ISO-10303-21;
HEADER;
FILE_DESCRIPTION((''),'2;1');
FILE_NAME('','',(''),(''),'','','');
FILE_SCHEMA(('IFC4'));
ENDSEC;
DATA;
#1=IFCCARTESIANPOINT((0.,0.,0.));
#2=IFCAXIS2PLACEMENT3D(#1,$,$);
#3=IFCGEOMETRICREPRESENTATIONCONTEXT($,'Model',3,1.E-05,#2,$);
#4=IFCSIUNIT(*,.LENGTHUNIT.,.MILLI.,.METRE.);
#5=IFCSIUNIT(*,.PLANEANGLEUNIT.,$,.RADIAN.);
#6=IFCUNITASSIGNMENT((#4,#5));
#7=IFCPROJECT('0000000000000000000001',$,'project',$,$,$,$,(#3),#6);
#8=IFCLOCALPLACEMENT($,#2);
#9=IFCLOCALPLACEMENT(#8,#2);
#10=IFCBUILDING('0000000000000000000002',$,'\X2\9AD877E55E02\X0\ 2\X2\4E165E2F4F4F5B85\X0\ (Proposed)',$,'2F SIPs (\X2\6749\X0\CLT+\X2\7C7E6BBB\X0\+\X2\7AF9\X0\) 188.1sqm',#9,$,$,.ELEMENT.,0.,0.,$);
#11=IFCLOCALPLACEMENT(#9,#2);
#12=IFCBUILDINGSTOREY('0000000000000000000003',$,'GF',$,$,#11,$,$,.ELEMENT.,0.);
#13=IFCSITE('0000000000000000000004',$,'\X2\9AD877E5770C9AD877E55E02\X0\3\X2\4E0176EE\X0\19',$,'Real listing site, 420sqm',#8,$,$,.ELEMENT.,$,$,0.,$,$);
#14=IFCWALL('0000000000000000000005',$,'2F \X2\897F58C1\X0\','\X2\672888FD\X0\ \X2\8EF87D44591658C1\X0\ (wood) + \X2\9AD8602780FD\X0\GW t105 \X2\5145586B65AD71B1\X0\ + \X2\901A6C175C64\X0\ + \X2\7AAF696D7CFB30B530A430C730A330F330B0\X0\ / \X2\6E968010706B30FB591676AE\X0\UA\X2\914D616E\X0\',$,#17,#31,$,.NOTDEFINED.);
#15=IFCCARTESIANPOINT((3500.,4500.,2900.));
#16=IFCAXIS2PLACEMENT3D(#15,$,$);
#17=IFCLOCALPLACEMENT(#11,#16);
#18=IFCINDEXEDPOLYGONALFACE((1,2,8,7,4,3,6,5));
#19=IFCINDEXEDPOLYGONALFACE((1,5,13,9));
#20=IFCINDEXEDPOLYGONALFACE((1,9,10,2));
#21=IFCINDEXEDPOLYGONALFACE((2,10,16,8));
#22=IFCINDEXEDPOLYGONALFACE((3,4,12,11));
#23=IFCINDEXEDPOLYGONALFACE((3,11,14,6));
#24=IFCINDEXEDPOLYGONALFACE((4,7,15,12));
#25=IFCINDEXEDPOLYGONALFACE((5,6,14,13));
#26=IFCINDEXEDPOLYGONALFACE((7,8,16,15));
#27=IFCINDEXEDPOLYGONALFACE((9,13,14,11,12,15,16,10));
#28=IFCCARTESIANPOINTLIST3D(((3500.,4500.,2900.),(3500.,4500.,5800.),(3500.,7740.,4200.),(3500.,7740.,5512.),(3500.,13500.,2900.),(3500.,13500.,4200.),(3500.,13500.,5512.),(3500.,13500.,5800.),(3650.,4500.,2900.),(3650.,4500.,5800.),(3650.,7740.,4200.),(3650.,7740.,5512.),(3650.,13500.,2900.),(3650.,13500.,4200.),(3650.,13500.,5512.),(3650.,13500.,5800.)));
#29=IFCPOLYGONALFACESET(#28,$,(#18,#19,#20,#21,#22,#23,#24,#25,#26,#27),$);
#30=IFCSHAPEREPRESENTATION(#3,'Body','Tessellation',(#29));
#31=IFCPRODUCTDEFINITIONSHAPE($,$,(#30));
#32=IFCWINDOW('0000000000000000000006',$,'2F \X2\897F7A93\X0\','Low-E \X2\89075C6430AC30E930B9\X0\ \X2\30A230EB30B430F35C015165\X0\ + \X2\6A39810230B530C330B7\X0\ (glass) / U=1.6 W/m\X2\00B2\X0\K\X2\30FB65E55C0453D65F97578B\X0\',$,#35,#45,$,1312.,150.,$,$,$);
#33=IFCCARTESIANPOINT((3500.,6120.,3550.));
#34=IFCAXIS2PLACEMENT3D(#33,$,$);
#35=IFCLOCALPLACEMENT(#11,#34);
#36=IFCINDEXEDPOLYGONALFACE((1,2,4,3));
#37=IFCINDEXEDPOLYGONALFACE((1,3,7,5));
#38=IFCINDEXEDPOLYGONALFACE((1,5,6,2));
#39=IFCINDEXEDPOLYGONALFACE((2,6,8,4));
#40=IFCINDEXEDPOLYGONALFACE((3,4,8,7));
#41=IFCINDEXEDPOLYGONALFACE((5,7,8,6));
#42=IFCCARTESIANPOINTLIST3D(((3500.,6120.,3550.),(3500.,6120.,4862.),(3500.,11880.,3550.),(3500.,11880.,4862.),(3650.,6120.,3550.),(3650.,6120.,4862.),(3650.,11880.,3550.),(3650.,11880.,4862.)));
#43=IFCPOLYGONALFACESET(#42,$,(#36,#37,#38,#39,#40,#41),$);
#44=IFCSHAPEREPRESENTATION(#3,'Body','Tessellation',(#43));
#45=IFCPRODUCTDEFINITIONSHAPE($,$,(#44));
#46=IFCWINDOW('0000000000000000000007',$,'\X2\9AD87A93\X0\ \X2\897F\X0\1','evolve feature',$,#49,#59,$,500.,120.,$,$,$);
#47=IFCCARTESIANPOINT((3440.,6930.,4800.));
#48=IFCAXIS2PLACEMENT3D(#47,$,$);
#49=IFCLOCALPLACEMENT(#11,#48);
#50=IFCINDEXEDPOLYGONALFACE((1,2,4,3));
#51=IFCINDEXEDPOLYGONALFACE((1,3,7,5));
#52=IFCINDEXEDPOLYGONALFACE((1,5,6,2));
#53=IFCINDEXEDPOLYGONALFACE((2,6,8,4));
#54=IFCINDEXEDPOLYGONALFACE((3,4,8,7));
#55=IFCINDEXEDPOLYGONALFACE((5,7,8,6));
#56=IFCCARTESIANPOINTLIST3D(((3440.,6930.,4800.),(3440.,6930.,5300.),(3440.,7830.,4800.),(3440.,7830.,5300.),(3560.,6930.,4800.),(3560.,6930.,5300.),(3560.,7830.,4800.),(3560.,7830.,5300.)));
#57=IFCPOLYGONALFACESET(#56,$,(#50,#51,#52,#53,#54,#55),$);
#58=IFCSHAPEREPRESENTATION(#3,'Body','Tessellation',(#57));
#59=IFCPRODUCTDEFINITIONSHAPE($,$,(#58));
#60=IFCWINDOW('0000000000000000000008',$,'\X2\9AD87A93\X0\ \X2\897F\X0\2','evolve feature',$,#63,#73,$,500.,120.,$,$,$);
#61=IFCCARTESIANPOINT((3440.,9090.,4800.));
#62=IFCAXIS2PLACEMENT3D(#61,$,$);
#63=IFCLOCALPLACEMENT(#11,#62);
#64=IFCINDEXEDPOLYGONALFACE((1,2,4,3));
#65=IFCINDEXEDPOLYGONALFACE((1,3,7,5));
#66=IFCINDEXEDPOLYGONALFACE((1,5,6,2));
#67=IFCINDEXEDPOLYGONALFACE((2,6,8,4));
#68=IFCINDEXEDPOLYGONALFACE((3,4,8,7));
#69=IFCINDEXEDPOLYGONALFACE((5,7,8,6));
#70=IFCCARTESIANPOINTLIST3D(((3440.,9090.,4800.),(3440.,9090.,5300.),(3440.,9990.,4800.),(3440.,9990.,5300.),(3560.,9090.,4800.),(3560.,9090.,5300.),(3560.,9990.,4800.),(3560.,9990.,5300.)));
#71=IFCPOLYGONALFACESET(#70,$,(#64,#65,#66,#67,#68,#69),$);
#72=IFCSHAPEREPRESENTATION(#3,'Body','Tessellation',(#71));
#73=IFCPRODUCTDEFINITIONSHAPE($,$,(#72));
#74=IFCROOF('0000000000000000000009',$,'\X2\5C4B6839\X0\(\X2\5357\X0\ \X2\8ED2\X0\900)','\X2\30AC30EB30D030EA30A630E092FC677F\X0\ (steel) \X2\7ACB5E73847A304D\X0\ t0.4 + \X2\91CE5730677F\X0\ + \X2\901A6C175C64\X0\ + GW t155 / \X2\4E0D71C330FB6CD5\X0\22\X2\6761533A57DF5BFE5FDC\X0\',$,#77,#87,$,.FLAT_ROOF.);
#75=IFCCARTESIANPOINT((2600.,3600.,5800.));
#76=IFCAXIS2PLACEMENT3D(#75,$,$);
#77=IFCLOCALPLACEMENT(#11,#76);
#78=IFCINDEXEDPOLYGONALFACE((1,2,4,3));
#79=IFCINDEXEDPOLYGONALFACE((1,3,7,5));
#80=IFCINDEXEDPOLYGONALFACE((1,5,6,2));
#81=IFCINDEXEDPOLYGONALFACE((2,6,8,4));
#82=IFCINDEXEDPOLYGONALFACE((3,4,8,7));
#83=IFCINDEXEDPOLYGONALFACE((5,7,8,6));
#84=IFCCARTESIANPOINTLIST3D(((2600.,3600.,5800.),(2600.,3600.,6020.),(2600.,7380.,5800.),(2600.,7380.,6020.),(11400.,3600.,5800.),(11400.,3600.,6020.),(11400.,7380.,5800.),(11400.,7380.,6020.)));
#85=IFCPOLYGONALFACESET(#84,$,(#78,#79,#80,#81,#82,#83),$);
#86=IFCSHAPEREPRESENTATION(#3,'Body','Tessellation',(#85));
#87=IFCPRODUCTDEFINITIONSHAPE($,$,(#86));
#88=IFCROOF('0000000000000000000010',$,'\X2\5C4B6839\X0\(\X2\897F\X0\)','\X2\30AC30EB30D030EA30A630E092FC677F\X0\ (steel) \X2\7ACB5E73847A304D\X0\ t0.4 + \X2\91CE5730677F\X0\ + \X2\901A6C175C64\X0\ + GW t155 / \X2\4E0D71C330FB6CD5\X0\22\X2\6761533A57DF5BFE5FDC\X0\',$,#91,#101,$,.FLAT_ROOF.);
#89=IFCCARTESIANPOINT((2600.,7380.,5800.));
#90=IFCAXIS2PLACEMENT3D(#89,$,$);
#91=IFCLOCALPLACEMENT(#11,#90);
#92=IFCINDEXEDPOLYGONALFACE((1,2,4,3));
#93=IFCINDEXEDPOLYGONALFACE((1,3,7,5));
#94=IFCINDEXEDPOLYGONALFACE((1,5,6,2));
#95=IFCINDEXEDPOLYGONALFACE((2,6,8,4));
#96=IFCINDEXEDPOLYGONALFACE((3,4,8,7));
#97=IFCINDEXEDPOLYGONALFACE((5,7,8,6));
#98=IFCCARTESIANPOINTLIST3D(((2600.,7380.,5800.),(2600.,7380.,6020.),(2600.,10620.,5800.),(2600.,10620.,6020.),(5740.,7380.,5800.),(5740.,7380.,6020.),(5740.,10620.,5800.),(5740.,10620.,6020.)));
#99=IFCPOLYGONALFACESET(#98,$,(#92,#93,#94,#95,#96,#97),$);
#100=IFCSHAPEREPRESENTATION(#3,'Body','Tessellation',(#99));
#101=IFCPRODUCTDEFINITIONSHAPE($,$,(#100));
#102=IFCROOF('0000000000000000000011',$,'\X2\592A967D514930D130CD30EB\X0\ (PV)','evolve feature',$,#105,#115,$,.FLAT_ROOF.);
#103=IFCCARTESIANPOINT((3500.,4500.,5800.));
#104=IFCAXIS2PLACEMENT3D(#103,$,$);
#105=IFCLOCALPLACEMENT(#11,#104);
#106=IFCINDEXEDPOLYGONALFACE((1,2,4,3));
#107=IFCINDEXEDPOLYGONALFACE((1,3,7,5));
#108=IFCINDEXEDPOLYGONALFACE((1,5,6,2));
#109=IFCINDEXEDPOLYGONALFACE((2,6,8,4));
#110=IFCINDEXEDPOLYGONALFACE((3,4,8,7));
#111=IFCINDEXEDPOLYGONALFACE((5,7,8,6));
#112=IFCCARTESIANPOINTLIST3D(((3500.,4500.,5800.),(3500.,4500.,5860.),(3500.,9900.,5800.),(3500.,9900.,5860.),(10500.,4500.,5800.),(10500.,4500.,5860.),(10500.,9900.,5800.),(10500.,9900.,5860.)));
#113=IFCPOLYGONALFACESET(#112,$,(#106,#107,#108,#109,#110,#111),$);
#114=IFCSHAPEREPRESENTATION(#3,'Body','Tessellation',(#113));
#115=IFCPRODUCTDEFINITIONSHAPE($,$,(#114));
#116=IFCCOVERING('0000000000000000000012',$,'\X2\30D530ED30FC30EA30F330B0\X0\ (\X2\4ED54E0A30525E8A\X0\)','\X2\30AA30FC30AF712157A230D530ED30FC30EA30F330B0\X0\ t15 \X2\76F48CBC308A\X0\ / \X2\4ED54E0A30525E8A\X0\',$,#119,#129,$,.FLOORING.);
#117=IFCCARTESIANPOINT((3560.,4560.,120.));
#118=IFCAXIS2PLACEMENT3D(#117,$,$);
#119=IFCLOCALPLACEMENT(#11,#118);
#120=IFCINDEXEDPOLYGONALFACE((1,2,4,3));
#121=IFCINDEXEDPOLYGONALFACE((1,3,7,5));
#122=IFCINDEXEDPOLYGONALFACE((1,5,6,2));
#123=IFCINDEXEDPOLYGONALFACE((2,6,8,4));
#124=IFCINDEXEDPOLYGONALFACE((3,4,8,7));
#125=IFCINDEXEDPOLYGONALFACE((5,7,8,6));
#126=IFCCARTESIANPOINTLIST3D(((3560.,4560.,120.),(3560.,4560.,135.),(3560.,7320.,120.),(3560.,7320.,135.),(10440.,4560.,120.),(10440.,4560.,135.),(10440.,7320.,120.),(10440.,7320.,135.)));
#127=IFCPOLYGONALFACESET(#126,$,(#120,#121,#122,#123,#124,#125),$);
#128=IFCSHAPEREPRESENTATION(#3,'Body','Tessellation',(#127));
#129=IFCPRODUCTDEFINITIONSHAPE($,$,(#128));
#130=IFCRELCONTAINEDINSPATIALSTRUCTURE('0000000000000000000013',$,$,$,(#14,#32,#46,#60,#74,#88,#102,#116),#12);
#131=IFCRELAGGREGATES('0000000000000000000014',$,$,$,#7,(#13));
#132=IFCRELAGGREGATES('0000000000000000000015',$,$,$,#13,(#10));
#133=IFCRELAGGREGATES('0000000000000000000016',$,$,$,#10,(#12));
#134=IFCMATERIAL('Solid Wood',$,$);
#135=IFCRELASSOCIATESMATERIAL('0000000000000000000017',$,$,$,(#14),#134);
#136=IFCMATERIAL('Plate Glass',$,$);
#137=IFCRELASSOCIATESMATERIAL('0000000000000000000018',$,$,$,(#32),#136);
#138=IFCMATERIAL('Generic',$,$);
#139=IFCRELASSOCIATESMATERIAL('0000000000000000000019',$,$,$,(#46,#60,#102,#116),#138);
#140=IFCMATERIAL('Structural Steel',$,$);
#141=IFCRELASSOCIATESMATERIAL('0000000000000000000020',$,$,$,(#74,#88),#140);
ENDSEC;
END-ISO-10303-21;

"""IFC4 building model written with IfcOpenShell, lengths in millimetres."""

from ifc_helpers import new_model, si_unit, frame, frame_2d, origin, place, context, project, spatial, rectangle, extrude, material, element, fill, save


model = new_model("IFC4")

# Units and contexts
model_context = context("Model", 3, precision=1e-05, world=origin())
ifc_project = project(units=[si_unit("LENGTHUNIT", "METRE", prefix="MILLI"), si_unit("PLANEANGLEUNIT", "RADIAN")], contexts=[model_context])

# Site, building, storey
site_placement = place(None, origin())
site = spatial("IfcSite", under=ifc_project, at=site_placement, Name="高知県高知市3丁目19", ObjectType="Real listing site, 420sqm", CompositionType="ELEMENT", RefElevation=0.0)
building_placement = place(site_placement, origin())
building = spatial("IfcBuilding", under=site, at=building_placement, Name="高知市 2世帯住宅 (Proposed)", ObjectType="2F SIPs (杉CLT+籾殻+竹) 188.1sqm", CompositionType="ELEMENT", ElevationOfRefHeight=0.0, ElevationOfTerrain=0.0)
storey_placement = place(building_placement, origin())
storey = spatial("IfcBuildingStorey", under=building, at=storey_placement, Name="GF", CompositionType="ELEMENT", Elevation=0.0)

# Shared definitions
ifc_material_1 = material(Name="Solid Wood")
ifc_material_2 = material(Name="Generic")

# Shared definitions
ifc_material_3 = material(Name="Plate Glass")

# Wall, openings, windows
wall_1_placement = place(storey_placement, frame((3500.0, 4500.0, 2900.0)))
wall_1 = element("IfcWall", 1, at=wall_1_placement, inside=storey, material=ifc_material_1, Name="2F 西壁", Description="木製 軸組外壁 (wood) + 高性能GW t105 充填断熱 + 通気層 + 窯業系サイディング / 準耐火・外皮UA配慮", PredefinedType="NOTDEFINED", context=model_context, shape_type="SweptSolid", body=[
    extrude(rectangle(XDim=150.0, YDim=9000.0, at=frame_2d((75.0, 4500.0))), frame((3500.0, 4500.0, 2900.0)), (0.0, 0.0, 1.0), 2900.0),
])
opening_1_placement = place(storey_placement, frame((3500.0, 6120.0, 3550.0)))
opening_1 = element("IfcOpeningElement", 2, at=opening_1_placement, cuts=wall_1, PredefinedType="NOTDEFINED", context=model_context, shape_type="SweptSolid", body=[
    extrude(rectangle(XDim=150.0, YDim=5760.0, at=frame_2d((75.0, 2880.0))), frame((3500.0, 6120.0, 3550.0)), (0.0, 0.0, 1.0), 1312.0),
])
opening_2_placement = place(storey_placement, frame((3440.0, 6930.0, 4800.0)))
opening_2 = element("IfcOpeningElement", 3, at=opening_2_placement, cuts=wall_1, PredefinedType="NOTDEFINED", context=model_context, shape_type="SweptSolid", body=[
    extrude(rectangle(XDim=120.0, YDim=900.0, at=frame_2d((60.0, 450.0))), frame((3440.0, 6930.0, 4800.0)), (0.0, 0.0, 1.0), 500.0),
])
opening_3_placement = place(storey_placement, frame((3440.0, 9090.0, 4800.0)))
opening_3 = element("IfcOpeningElement", 4, at=opening_3_placement, cuts=wall_1, PredefinedType="NOTDEFINED", context=model_context, shape_type="SweptSolid", body=[
    extrude(rectangle(XDim=120.0, YDim=900.0, at=frame_2d((60.0, 450.0))), frame((3440.0, 9090.0, 4800.0)), (0.0, 0.0, 1.0), 500.0),
])
window_1_placement = place(storey_placement, frame((3500.0, 6120.0, 3550.0)))
window_1 = element("IfcWindow", 5, at=window_1_placement, inside=storey, material=ifc_material_3, Name="2F 西窓", Description="Low-E 複層ガラス アルゴン封入 + 樹脂サッシ (glass) / U=1.6 W/m²K・日射取得型", OverallHeight=1312.0, OverallWidth=150.0, context=model_context, shape_type="SweptSolid", body=[
    extrude(rectangle(XDim=150.0, YDim=5760.0, at=frame_2d((75.0, 2880.0))), frame((3500.0, 6120.0, 3550.0)), (0.0, 0.0, 1.0), 1312.0),
])
fill(opening_1, window_1)
window_2_placement = place(storey_placement, frame((3440.0, 6930.0, 4800.0)))
window_2 = element("IfcWindow", 6, at=window_2_placement, inside=storey, material=ifc_material_2, Name="高窓 西1", Description="evolve feature", OverallHeight=500.0, OverallWidth=120.0, context=model_context, shape_type="SweptSolid", body=[
    extrude(rectangle(XDim=120.0, YDim=900.0, at=frame_2d((60.0, 450.0))), frame((3440.0, 6930.0, 4800.0)), (0.0, 0.0, 1.0), 500.0),
])
fill(opening_2, window_2)
window_3_placement = place(storey_placement, frame((3440.0, 9090.0, 4800.0)))
window_3 = element("IfcWindow", 7, at=window_3_placement, inside=storey, material=ifc_material_2, Name="高窓 西2", Description="evolve feature", OverallHeight=500.0, OverallWidth=120.0, context=model_context, shape_type="SweptSolid", body=[
    extrude(rectangle(XDim=120.0, YDim=900.0, at=frame_2d((60.0, 450.0))), frame((3440.0, 9090.0, 4800.0)), (0.0, 0.0, 1.0), 500.0),
])
fill(opening_3, window_3)

# Roofs
ifc_material_4 = material(Name="Structural Steel")
roof_1_placement = place(storey_placement, frame((2600.0, 3600.0, 5800.0)))
element("IfcRoof", 8, at=roof_1_placement, inside=storey, material=ifc_material_4, Name="屋根(南 軒900)", Description="ガルバリウム鋼板 (steel) 立平葺き t0.4 + 野地板 + 通気層 + GW t155 / 不燃・法22条区域対応", PredefinedType="FLAT_ROOF", context=model_context, shape_type="SweptSolid", body=[
    extrude(rectangle(XDim=8800.0, YDim=3780.0, at=frame_2d((4400.0, 1890.0))), frame((2600.0, 3600.0, 5800.0)), (0.0, 0.0, 1.0), 220.0),
])
roof_2_placement = place(storey_placement, frame((2600.0, 7380.0, 5800.0)))
element("IfcRoof", 9, at=roof_2_placement, inside=storey, material=ifc_material_4, Name="屋根(西)", Description="ガルバリウム鋼板 (steel) 立平葺き t0.4 + 野地板 + 通気層 + GW t155 / 不燃・法22条区域対応", PredefinedType="FLAT_ROOF", context=model_context, shape_type="SweptSolid", body=[
    extrude(rectangle(XDim=3140.0, YDim=3240.0, at=frame_2d((1570.0, 1620.0))), frame((2600.0, 7380.0, 5800.0)), (0.0, 0.0, 1.0), 220.0),
])
roof_3_placement = place(storey_placement, frame((3500.0, 4500.0, 5800.0)))
element("IfcRoof", 10, at=roof_3_placement, inside=storey, material=ifc_material_2, Name="太陽光パネル (PV)", Description="evolve feature", PredefinedType="FLAT_ROOF", context=model_context, shape_type="SweptSolid", body=[
    extrude(rectangle(XDim=7000.0, YDim=5400.0, at=frame_2d((3500.0, 2700.0))), frame((3500.0, 4500.0, 5800.0)), (0.0, 0.0, 1.0), 60.0),
])

# Covering
covering_placement = place(storey_placement, frame((3560.0, 4560.0, 120.0)))
element("IfcCovering", 11, at=covering_placement, inside=storey, material=ifc_material_2, Name="フローリング (仕上げ床)", Description="オーク無垢フローリング t15 直貼り / 仕上げ床", PredefinedType="FLOORING", context=model_context, shape_type="SweptSolid", body=[
    extrude(rectangle(XDim=6880.0, YDim=2760.0, at=frame_2d((3440.0, 1380.0))), frame((3560.0, 4560.0, 120.0)), (0.0, 0.0, 1.0), 15.0),
])

save(model, "model.ifc")
